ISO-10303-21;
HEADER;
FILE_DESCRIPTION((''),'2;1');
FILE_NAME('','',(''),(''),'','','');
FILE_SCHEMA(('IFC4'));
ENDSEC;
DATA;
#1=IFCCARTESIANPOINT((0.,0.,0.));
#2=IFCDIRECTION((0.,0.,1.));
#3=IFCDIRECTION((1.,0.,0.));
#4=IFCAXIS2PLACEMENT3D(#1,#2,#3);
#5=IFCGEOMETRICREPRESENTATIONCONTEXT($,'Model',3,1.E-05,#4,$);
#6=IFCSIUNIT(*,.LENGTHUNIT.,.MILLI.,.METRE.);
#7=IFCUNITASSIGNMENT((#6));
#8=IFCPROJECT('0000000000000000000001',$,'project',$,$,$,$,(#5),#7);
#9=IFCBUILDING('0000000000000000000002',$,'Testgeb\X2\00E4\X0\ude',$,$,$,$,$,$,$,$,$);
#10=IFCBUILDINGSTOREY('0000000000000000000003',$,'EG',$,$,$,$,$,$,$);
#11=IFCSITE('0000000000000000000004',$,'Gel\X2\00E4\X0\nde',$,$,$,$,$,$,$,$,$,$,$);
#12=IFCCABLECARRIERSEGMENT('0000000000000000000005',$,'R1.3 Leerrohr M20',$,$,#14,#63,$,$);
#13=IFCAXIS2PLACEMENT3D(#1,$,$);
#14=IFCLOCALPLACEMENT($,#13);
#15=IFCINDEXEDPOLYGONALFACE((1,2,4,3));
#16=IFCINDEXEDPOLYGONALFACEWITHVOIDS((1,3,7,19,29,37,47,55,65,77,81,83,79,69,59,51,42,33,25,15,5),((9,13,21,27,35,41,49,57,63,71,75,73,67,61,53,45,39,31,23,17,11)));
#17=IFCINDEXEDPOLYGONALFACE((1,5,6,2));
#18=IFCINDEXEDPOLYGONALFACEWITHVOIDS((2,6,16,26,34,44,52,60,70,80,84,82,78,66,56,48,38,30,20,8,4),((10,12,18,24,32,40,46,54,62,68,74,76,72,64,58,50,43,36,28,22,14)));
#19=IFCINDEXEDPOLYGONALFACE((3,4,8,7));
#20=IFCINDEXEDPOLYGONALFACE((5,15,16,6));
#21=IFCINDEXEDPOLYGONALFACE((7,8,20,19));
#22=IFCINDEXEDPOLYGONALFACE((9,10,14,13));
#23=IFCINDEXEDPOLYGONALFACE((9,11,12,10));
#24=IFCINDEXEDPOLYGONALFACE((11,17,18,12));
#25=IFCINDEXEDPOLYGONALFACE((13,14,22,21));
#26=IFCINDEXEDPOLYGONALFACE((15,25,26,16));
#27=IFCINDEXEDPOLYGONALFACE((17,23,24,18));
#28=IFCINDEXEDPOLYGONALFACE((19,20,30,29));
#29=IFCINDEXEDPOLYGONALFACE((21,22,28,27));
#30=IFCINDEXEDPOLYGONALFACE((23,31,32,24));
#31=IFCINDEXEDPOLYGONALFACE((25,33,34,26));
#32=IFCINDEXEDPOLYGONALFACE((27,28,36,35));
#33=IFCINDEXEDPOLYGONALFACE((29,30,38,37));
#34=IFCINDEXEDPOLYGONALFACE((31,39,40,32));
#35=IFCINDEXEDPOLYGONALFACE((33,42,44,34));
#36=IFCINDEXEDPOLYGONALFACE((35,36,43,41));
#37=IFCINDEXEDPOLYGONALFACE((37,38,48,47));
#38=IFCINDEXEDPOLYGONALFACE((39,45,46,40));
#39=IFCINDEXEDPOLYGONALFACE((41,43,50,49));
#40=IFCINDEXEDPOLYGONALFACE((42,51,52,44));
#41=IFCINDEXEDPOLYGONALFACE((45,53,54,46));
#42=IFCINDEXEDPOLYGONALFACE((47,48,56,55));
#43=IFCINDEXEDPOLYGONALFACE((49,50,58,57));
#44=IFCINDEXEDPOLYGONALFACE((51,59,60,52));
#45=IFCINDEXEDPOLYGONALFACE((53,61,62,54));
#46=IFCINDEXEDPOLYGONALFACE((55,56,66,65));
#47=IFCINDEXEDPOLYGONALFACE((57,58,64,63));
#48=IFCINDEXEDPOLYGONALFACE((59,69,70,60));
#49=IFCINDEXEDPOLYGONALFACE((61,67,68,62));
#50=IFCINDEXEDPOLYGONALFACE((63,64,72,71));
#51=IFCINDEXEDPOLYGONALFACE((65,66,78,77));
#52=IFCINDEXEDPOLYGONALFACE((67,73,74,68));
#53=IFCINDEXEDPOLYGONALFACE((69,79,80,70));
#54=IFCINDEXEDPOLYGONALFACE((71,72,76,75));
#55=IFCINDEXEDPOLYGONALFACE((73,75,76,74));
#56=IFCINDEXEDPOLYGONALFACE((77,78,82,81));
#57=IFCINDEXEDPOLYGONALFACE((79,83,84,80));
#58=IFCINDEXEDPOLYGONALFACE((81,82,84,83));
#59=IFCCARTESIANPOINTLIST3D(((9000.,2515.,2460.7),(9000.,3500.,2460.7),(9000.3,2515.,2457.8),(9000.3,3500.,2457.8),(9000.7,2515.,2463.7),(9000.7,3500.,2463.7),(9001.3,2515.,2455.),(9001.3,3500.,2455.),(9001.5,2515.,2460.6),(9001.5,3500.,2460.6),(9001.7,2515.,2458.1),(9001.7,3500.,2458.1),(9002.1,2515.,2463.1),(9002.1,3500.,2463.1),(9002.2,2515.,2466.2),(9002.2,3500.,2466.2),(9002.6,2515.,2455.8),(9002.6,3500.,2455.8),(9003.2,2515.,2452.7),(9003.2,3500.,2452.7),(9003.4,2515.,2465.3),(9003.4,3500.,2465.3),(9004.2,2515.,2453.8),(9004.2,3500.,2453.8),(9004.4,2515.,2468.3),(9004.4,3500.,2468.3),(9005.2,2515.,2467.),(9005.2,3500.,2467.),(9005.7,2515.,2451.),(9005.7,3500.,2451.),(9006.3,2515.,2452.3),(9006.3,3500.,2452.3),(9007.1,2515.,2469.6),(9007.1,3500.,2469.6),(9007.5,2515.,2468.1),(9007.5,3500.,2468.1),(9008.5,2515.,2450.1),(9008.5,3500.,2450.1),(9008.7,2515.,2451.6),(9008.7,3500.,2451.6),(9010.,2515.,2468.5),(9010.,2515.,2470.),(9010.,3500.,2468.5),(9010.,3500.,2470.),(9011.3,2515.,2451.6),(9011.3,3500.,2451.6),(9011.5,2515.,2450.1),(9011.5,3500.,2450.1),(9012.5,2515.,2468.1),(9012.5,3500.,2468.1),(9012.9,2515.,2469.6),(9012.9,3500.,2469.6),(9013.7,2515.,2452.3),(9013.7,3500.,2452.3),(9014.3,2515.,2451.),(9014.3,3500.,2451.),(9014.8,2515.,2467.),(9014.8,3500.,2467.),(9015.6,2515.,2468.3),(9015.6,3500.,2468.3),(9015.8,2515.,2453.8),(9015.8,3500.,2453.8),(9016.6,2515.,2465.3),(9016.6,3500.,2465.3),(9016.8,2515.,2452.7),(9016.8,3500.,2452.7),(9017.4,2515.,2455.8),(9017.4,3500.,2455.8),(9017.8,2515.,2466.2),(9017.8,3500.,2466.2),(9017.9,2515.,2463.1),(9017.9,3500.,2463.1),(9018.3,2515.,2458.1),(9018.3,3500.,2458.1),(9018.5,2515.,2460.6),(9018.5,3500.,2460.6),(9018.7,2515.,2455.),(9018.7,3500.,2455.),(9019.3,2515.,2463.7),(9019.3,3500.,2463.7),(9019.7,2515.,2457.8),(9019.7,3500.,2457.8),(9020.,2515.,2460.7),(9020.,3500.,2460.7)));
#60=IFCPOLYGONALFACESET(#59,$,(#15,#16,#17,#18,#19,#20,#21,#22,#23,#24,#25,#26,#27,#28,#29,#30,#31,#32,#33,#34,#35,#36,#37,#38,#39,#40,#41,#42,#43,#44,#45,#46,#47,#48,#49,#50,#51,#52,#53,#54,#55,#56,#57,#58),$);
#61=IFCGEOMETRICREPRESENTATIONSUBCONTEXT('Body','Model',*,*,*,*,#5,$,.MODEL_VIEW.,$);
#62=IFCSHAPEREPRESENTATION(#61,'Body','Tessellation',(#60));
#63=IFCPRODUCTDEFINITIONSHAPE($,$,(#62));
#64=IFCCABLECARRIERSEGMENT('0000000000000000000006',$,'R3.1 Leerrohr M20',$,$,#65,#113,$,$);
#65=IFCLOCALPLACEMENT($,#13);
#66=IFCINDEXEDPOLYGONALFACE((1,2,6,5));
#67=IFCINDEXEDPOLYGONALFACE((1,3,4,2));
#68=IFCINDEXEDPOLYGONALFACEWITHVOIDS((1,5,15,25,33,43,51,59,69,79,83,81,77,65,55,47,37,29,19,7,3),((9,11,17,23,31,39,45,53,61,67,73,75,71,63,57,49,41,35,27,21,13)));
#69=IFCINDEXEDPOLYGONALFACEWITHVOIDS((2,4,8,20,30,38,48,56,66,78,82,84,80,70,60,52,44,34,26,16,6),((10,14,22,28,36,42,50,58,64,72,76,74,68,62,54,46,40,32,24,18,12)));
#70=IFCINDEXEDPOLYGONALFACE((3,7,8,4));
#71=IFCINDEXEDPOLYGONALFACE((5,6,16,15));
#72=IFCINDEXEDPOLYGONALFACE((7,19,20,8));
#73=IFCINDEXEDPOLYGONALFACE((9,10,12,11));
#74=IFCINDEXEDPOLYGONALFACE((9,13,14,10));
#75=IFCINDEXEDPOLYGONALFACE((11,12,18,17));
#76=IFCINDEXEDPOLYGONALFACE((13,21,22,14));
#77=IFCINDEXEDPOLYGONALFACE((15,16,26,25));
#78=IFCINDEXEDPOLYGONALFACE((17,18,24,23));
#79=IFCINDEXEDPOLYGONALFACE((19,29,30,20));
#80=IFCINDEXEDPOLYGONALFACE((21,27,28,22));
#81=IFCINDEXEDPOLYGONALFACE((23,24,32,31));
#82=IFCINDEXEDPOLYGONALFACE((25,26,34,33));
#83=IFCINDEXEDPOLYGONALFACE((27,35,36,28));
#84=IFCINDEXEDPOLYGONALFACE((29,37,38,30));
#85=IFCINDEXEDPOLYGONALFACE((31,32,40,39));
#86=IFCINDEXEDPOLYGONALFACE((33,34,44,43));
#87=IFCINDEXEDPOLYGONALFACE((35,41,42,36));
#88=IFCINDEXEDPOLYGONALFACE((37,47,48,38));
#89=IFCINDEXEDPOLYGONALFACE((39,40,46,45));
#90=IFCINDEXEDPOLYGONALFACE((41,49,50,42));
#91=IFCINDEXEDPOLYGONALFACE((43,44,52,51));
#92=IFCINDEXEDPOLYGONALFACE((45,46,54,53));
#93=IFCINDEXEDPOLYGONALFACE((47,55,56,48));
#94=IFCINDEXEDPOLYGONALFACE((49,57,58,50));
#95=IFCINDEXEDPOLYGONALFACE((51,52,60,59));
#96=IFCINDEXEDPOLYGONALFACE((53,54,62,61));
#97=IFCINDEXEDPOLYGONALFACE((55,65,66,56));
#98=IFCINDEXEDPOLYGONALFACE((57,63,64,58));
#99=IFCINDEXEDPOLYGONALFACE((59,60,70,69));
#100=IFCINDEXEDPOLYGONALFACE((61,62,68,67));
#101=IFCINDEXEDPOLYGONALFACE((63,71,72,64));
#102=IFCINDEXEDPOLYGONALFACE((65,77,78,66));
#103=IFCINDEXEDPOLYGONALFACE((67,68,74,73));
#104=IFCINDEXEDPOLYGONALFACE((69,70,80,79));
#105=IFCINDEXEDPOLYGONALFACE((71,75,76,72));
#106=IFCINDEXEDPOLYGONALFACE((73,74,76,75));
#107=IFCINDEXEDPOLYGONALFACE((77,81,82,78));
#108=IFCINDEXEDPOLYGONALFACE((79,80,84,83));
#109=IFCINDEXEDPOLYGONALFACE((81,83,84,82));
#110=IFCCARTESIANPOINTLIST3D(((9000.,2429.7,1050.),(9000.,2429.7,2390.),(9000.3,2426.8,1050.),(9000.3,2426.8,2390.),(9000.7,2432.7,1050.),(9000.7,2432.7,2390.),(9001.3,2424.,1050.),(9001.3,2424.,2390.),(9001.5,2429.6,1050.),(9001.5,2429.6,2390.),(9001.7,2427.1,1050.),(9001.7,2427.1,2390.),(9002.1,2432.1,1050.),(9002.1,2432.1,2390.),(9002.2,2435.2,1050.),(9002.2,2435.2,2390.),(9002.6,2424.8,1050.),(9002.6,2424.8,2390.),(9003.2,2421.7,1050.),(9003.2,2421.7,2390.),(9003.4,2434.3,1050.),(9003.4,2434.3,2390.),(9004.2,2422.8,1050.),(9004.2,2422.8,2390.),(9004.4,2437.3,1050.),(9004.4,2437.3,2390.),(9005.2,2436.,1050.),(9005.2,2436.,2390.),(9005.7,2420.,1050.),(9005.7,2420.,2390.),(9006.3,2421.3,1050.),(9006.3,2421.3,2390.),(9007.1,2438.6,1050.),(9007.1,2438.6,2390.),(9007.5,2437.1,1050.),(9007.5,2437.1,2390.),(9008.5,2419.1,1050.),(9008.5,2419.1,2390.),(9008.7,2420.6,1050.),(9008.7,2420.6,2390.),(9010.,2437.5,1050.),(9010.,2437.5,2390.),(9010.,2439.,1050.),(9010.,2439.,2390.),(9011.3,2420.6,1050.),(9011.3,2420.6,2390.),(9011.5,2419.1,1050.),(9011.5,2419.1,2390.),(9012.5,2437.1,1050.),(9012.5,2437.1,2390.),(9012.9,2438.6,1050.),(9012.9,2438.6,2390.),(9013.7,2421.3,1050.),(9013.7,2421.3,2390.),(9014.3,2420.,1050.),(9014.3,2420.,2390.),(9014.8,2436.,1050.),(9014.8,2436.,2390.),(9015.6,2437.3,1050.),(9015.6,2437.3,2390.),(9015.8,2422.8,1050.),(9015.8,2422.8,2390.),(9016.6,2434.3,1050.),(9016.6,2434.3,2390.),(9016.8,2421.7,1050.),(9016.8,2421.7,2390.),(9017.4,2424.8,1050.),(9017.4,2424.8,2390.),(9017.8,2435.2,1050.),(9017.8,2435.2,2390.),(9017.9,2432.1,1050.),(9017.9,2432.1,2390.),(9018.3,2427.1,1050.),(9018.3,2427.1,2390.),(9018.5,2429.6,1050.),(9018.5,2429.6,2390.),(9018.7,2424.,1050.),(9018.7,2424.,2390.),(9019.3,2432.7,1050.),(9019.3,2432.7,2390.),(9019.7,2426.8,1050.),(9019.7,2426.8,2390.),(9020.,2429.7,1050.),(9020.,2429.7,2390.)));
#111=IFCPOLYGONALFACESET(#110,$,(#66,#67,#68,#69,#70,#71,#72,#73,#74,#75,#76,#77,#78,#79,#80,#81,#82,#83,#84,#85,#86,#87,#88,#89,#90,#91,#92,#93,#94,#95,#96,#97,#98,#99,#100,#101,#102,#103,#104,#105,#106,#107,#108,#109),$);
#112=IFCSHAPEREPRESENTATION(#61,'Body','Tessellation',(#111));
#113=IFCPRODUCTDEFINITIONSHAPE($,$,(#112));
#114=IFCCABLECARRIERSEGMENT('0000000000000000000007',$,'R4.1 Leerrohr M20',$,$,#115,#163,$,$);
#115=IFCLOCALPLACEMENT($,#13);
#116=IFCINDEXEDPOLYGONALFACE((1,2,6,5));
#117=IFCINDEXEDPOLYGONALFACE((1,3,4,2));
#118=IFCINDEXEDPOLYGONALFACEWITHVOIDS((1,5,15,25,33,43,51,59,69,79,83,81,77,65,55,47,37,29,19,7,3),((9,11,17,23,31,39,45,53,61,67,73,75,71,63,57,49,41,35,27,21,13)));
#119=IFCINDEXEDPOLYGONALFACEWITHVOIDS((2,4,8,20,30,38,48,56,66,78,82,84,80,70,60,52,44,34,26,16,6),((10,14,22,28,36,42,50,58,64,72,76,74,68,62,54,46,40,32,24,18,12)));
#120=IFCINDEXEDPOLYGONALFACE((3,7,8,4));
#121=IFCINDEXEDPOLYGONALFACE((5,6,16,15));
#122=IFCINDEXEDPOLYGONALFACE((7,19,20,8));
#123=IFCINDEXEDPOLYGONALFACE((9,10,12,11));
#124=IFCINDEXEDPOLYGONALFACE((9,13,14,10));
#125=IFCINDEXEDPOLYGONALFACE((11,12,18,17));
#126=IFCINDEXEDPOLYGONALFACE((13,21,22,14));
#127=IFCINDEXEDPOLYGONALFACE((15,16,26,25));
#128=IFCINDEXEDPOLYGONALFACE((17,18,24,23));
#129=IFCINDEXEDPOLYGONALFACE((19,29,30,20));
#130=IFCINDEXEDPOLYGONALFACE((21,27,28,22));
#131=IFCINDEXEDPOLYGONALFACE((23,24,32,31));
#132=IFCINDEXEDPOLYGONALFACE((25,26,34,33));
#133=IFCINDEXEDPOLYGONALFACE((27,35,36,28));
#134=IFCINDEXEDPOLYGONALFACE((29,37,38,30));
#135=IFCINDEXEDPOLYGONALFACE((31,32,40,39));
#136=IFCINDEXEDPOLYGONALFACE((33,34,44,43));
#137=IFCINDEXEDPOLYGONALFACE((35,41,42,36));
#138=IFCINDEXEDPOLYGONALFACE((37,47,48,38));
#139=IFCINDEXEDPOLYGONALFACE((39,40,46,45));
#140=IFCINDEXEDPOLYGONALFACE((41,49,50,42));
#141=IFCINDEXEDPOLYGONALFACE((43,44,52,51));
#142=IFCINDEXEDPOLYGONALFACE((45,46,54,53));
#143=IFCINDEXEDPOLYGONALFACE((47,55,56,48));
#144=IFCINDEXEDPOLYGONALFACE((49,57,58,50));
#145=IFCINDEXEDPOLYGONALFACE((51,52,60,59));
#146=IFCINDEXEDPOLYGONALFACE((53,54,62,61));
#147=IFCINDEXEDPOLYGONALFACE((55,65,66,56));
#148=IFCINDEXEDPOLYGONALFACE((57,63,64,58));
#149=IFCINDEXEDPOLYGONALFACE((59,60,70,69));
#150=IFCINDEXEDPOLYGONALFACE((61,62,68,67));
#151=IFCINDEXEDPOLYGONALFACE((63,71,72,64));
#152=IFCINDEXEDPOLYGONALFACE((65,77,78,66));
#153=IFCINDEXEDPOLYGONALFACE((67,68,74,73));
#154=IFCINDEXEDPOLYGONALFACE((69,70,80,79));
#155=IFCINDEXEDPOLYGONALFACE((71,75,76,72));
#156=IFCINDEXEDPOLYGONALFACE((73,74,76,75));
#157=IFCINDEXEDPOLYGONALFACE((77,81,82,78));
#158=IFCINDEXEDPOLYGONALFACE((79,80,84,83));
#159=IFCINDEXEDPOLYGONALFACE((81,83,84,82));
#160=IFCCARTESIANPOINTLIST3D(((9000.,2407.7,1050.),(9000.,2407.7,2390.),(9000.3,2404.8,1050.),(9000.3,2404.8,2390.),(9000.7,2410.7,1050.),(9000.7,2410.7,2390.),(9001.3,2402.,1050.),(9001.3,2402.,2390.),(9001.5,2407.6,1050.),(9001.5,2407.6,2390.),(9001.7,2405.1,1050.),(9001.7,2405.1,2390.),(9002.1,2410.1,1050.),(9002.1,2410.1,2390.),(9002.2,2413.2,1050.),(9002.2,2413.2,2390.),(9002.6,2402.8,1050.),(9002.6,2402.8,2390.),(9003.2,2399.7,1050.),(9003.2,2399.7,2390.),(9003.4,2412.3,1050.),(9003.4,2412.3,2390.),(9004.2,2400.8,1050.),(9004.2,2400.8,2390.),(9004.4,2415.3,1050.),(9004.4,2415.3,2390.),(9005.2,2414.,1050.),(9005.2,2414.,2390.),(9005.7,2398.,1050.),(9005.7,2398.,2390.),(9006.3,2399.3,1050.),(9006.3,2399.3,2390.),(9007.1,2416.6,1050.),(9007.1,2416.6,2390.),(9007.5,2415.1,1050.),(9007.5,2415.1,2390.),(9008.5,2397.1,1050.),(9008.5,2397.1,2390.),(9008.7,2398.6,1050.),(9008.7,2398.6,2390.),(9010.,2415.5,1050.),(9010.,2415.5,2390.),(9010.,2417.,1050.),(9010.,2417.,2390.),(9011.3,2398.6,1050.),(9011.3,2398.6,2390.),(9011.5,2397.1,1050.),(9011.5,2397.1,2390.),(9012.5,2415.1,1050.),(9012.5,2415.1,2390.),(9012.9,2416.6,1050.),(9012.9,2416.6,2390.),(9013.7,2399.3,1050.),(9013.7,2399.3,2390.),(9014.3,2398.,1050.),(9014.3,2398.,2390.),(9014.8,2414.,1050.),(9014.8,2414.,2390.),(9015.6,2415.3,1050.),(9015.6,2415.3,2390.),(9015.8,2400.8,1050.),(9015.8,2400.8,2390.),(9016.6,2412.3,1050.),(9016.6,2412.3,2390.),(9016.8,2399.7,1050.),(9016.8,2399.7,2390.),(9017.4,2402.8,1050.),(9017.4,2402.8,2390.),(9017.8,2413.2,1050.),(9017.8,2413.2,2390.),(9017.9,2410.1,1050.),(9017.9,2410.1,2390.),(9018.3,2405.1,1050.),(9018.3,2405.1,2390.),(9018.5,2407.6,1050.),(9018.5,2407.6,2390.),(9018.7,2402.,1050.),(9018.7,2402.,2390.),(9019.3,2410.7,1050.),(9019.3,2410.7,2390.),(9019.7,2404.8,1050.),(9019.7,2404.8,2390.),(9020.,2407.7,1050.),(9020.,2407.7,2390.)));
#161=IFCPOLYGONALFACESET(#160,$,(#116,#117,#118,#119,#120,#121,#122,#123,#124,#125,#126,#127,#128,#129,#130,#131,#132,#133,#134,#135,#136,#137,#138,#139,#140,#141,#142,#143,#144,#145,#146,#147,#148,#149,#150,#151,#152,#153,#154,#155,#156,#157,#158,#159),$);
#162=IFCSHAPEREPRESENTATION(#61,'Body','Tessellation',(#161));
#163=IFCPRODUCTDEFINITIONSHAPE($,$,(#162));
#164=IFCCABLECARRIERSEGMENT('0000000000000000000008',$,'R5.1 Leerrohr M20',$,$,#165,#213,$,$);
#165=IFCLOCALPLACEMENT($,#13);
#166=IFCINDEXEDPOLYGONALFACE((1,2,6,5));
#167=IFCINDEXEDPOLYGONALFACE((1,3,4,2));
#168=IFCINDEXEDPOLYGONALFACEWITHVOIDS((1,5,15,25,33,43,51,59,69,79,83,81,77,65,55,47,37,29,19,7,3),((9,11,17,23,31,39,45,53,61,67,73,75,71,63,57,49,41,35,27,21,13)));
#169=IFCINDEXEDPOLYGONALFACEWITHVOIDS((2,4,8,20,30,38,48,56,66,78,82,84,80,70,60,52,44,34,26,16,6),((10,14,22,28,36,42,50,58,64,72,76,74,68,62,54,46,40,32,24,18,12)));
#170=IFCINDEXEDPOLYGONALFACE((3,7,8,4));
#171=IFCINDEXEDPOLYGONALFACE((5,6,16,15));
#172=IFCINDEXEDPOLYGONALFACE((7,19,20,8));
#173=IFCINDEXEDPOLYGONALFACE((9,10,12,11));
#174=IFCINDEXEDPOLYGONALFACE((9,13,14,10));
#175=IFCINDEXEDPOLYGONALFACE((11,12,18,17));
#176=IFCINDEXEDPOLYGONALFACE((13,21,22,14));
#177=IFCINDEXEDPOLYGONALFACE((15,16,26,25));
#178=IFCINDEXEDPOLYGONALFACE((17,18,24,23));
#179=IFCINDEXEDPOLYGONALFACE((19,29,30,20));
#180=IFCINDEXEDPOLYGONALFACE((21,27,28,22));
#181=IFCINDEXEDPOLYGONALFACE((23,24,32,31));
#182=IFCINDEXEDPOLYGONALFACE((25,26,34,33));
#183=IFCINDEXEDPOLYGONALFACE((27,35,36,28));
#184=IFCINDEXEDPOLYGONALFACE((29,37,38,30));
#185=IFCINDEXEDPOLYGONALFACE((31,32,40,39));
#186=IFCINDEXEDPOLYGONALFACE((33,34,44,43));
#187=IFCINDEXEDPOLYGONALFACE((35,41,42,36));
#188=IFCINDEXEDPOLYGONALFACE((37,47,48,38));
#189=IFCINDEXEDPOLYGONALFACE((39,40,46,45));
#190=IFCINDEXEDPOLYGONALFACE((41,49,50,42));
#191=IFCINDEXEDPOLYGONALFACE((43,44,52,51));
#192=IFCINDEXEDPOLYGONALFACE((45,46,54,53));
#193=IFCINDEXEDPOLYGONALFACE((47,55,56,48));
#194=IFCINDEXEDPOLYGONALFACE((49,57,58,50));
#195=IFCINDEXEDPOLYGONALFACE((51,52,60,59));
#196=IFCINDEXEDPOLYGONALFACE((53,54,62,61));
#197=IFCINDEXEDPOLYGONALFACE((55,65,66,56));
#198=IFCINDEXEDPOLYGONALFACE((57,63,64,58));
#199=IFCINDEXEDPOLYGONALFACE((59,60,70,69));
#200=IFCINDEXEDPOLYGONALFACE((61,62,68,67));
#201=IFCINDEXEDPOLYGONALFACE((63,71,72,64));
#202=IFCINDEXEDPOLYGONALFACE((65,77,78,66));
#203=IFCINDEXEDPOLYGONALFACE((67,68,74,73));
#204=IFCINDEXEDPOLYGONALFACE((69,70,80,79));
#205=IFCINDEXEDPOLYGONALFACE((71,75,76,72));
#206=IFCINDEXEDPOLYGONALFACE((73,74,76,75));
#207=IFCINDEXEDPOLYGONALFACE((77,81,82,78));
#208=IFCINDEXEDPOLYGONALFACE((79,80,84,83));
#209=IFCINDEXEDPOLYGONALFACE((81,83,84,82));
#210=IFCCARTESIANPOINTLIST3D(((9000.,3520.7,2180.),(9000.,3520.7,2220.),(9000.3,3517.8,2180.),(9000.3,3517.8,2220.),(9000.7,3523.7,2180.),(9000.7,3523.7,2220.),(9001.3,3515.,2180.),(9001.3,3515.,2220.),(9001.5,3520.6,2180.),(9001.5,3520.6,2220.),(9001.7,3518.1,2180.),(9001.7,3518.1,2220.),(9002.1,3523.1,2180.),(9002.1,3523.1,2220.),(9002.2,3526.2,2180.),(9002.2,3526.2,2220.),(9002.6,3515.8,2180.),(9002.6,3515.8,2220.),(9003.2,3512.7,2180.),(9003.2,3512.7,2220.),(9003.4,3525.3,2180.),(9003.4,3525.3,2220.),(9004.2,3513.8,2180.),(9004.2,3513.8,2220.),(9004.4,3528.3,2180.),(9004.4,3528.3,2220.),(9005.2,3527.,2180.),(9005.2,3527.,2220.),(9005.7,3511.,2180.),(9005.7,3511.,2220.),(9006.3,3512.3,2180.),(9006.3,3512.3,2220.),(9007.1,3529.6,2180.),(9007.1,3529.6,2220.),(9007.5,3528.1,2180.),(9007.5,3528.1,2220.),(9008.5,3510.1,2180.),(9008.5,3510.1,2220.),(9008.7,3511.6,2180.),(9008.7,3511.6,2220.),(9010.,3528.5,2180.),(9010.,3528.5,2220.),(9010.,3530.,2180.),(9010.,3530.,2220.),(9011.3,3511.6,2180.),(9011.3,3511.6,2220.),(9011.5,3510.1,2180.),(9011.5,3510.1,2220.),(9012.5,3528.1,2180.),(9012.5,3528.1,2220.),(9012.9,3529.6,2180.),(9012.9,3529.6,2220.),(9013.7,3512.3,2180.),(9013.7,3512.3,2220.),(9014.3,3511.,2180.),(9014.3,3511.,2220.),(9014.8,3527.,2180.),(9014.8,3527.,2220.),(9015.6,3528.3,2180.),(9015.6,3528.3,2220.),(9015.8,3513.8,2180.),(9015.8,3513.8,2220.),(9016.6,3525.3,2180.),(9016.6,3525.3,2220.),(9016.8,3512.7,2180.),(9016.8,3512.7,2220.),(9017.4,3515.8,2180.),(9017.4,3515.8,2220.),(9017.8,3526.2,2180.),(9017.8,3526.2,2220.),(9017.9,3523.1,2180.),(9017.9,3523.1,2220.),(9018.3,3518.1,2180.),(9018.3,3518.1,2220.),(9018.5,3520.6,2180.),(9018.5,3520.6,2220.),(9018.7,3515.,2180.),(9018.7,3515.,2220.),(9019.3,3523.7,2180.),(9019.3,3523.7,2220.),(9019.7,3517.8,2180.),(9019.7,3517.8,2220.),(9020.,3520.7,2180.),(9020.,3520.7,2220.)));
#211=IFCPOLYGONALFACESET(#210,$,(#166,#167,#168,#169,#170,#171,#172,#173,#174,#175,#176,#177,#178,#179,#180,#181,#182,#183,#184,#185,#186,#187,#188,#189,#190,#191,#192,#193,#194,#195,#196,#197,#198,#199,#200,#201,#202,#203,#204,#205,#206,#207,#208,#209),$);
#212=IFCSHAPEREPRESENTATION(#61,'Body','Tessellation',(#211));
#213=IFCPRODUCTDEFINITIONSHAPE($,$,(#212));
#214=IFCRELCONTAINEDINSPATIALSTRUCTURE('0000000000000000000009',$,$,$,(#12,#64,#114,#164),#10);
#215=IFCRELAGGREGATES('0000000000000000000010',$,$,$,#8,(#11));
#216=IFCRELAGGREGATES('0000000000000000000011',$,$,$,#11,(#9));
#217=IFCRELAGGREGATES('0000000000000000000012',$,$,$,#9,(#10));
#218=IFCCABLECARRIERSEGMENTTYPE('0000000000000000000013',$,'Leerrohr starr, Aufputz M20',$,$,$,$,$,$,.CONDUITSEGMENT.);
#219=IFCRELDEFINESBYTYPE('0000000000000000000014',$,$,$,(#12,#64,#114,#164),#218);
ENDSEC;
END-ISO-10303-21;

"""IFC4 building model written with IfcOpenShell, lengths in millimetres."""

from ifc_helpers import new_model, si_unit, frame, origin_with_axes, place, context, subcontext, project, spatial, hollow_circle, extrude, type_object, element, save


model = new_model("IFC4")

# Units and contexts
model_context = context("Model", 3, precision=1e-05, world=origin_with_axes())
body_context = subcontext(model_context, "Body", "Model", "MODEL_VIEW")
ifc_project = project(units=[si_unit("LENGTHUNIT", "METRE", prefix="MILLI")], contexts=[model_context])

# Site, building, storey
site = spatial("IfcSite", under=ifc_project, Name="Gelände")
building = spatial("IfcBuilding", under=site, Name="Testgebäude")
storey = spatial("IfcBuildingStorey", under=building, Name="EG")

# Cable carrier segments
cable_carrier_segment_type_1 = type_object("IfcCableCarrierSegmentType", Name="Leerrohr starr, Aufputz M20", PredefinedType="CONDUITSEGMENT")
cable_carrier_segment_1_placement = place(None, frame((9010.0, 3500.0, 2460.0), z_axis=(0.0, -1.0, 0.0), x_axis=(0.0, 0.0, 1.0)))
element("IfcCableCarrierSegment", 1, at=cable_carrier_segment_1_placement, inside=storey, type_object=cable_carrier_segment_type_1, Name="R1.3 Leerrohr M20", context=body_context, shape_type="SweptSolid", body=[
    extrude(hollow_circle(Radius=10.0, WallThickness=1.5), None, (0.0, 0.0, 1.0), 985.0),
])
for number, where, z_axis, x_axis, name in (
    (2, (9010.0, 2429.0, 1050.0), (0.0, 0.0, 1.0), (0.0, 1.0, 0.0), "R3.1 Leerrohr M20"),
    (3, (9010.0, 2407.0, 1050.0), (0.0, 0.0, 1.0), (0.0, 1.0, 0.0), "R4.1 Leerrohr M20"),
):
    element("IfcCableCarrierSegment", number, at=place(None, frame(where, z_axis=z_axis, x_axis=x_axis)), inside=storey, type_object=cable_carrier_segment_type_1, Name=name, context=body_context, shape_type="SweptSolid", body=[
        extrude(hollow_circle(Radius=10.0, WallThickness=1.5), None, (0.0, 0.0, 1.0), 1340.0),
    ])
cable_carrier_segment_2_placement = place(None, frame((9010.0, 3520.0, 2180.0), z_axis=(0.0, 0.0, 1.0), x_axis=(0.0, 1.0, 0.0)))
element("IfcCableCarrierSegment", 4, at=cable_carrier_segment_2_placement, inside=storey, type_object=cable_carrier_segment_type_1, Name="R5.1 Leerrohr M20", context=body_context, shape_type="SweptSolid", body=[
    extrude(hollow_circle(Radius=10.0, WallThickness=1.5), None, (0.0, 0.0, 1.0), 40.0),
])

save(model, "model.ifc")
